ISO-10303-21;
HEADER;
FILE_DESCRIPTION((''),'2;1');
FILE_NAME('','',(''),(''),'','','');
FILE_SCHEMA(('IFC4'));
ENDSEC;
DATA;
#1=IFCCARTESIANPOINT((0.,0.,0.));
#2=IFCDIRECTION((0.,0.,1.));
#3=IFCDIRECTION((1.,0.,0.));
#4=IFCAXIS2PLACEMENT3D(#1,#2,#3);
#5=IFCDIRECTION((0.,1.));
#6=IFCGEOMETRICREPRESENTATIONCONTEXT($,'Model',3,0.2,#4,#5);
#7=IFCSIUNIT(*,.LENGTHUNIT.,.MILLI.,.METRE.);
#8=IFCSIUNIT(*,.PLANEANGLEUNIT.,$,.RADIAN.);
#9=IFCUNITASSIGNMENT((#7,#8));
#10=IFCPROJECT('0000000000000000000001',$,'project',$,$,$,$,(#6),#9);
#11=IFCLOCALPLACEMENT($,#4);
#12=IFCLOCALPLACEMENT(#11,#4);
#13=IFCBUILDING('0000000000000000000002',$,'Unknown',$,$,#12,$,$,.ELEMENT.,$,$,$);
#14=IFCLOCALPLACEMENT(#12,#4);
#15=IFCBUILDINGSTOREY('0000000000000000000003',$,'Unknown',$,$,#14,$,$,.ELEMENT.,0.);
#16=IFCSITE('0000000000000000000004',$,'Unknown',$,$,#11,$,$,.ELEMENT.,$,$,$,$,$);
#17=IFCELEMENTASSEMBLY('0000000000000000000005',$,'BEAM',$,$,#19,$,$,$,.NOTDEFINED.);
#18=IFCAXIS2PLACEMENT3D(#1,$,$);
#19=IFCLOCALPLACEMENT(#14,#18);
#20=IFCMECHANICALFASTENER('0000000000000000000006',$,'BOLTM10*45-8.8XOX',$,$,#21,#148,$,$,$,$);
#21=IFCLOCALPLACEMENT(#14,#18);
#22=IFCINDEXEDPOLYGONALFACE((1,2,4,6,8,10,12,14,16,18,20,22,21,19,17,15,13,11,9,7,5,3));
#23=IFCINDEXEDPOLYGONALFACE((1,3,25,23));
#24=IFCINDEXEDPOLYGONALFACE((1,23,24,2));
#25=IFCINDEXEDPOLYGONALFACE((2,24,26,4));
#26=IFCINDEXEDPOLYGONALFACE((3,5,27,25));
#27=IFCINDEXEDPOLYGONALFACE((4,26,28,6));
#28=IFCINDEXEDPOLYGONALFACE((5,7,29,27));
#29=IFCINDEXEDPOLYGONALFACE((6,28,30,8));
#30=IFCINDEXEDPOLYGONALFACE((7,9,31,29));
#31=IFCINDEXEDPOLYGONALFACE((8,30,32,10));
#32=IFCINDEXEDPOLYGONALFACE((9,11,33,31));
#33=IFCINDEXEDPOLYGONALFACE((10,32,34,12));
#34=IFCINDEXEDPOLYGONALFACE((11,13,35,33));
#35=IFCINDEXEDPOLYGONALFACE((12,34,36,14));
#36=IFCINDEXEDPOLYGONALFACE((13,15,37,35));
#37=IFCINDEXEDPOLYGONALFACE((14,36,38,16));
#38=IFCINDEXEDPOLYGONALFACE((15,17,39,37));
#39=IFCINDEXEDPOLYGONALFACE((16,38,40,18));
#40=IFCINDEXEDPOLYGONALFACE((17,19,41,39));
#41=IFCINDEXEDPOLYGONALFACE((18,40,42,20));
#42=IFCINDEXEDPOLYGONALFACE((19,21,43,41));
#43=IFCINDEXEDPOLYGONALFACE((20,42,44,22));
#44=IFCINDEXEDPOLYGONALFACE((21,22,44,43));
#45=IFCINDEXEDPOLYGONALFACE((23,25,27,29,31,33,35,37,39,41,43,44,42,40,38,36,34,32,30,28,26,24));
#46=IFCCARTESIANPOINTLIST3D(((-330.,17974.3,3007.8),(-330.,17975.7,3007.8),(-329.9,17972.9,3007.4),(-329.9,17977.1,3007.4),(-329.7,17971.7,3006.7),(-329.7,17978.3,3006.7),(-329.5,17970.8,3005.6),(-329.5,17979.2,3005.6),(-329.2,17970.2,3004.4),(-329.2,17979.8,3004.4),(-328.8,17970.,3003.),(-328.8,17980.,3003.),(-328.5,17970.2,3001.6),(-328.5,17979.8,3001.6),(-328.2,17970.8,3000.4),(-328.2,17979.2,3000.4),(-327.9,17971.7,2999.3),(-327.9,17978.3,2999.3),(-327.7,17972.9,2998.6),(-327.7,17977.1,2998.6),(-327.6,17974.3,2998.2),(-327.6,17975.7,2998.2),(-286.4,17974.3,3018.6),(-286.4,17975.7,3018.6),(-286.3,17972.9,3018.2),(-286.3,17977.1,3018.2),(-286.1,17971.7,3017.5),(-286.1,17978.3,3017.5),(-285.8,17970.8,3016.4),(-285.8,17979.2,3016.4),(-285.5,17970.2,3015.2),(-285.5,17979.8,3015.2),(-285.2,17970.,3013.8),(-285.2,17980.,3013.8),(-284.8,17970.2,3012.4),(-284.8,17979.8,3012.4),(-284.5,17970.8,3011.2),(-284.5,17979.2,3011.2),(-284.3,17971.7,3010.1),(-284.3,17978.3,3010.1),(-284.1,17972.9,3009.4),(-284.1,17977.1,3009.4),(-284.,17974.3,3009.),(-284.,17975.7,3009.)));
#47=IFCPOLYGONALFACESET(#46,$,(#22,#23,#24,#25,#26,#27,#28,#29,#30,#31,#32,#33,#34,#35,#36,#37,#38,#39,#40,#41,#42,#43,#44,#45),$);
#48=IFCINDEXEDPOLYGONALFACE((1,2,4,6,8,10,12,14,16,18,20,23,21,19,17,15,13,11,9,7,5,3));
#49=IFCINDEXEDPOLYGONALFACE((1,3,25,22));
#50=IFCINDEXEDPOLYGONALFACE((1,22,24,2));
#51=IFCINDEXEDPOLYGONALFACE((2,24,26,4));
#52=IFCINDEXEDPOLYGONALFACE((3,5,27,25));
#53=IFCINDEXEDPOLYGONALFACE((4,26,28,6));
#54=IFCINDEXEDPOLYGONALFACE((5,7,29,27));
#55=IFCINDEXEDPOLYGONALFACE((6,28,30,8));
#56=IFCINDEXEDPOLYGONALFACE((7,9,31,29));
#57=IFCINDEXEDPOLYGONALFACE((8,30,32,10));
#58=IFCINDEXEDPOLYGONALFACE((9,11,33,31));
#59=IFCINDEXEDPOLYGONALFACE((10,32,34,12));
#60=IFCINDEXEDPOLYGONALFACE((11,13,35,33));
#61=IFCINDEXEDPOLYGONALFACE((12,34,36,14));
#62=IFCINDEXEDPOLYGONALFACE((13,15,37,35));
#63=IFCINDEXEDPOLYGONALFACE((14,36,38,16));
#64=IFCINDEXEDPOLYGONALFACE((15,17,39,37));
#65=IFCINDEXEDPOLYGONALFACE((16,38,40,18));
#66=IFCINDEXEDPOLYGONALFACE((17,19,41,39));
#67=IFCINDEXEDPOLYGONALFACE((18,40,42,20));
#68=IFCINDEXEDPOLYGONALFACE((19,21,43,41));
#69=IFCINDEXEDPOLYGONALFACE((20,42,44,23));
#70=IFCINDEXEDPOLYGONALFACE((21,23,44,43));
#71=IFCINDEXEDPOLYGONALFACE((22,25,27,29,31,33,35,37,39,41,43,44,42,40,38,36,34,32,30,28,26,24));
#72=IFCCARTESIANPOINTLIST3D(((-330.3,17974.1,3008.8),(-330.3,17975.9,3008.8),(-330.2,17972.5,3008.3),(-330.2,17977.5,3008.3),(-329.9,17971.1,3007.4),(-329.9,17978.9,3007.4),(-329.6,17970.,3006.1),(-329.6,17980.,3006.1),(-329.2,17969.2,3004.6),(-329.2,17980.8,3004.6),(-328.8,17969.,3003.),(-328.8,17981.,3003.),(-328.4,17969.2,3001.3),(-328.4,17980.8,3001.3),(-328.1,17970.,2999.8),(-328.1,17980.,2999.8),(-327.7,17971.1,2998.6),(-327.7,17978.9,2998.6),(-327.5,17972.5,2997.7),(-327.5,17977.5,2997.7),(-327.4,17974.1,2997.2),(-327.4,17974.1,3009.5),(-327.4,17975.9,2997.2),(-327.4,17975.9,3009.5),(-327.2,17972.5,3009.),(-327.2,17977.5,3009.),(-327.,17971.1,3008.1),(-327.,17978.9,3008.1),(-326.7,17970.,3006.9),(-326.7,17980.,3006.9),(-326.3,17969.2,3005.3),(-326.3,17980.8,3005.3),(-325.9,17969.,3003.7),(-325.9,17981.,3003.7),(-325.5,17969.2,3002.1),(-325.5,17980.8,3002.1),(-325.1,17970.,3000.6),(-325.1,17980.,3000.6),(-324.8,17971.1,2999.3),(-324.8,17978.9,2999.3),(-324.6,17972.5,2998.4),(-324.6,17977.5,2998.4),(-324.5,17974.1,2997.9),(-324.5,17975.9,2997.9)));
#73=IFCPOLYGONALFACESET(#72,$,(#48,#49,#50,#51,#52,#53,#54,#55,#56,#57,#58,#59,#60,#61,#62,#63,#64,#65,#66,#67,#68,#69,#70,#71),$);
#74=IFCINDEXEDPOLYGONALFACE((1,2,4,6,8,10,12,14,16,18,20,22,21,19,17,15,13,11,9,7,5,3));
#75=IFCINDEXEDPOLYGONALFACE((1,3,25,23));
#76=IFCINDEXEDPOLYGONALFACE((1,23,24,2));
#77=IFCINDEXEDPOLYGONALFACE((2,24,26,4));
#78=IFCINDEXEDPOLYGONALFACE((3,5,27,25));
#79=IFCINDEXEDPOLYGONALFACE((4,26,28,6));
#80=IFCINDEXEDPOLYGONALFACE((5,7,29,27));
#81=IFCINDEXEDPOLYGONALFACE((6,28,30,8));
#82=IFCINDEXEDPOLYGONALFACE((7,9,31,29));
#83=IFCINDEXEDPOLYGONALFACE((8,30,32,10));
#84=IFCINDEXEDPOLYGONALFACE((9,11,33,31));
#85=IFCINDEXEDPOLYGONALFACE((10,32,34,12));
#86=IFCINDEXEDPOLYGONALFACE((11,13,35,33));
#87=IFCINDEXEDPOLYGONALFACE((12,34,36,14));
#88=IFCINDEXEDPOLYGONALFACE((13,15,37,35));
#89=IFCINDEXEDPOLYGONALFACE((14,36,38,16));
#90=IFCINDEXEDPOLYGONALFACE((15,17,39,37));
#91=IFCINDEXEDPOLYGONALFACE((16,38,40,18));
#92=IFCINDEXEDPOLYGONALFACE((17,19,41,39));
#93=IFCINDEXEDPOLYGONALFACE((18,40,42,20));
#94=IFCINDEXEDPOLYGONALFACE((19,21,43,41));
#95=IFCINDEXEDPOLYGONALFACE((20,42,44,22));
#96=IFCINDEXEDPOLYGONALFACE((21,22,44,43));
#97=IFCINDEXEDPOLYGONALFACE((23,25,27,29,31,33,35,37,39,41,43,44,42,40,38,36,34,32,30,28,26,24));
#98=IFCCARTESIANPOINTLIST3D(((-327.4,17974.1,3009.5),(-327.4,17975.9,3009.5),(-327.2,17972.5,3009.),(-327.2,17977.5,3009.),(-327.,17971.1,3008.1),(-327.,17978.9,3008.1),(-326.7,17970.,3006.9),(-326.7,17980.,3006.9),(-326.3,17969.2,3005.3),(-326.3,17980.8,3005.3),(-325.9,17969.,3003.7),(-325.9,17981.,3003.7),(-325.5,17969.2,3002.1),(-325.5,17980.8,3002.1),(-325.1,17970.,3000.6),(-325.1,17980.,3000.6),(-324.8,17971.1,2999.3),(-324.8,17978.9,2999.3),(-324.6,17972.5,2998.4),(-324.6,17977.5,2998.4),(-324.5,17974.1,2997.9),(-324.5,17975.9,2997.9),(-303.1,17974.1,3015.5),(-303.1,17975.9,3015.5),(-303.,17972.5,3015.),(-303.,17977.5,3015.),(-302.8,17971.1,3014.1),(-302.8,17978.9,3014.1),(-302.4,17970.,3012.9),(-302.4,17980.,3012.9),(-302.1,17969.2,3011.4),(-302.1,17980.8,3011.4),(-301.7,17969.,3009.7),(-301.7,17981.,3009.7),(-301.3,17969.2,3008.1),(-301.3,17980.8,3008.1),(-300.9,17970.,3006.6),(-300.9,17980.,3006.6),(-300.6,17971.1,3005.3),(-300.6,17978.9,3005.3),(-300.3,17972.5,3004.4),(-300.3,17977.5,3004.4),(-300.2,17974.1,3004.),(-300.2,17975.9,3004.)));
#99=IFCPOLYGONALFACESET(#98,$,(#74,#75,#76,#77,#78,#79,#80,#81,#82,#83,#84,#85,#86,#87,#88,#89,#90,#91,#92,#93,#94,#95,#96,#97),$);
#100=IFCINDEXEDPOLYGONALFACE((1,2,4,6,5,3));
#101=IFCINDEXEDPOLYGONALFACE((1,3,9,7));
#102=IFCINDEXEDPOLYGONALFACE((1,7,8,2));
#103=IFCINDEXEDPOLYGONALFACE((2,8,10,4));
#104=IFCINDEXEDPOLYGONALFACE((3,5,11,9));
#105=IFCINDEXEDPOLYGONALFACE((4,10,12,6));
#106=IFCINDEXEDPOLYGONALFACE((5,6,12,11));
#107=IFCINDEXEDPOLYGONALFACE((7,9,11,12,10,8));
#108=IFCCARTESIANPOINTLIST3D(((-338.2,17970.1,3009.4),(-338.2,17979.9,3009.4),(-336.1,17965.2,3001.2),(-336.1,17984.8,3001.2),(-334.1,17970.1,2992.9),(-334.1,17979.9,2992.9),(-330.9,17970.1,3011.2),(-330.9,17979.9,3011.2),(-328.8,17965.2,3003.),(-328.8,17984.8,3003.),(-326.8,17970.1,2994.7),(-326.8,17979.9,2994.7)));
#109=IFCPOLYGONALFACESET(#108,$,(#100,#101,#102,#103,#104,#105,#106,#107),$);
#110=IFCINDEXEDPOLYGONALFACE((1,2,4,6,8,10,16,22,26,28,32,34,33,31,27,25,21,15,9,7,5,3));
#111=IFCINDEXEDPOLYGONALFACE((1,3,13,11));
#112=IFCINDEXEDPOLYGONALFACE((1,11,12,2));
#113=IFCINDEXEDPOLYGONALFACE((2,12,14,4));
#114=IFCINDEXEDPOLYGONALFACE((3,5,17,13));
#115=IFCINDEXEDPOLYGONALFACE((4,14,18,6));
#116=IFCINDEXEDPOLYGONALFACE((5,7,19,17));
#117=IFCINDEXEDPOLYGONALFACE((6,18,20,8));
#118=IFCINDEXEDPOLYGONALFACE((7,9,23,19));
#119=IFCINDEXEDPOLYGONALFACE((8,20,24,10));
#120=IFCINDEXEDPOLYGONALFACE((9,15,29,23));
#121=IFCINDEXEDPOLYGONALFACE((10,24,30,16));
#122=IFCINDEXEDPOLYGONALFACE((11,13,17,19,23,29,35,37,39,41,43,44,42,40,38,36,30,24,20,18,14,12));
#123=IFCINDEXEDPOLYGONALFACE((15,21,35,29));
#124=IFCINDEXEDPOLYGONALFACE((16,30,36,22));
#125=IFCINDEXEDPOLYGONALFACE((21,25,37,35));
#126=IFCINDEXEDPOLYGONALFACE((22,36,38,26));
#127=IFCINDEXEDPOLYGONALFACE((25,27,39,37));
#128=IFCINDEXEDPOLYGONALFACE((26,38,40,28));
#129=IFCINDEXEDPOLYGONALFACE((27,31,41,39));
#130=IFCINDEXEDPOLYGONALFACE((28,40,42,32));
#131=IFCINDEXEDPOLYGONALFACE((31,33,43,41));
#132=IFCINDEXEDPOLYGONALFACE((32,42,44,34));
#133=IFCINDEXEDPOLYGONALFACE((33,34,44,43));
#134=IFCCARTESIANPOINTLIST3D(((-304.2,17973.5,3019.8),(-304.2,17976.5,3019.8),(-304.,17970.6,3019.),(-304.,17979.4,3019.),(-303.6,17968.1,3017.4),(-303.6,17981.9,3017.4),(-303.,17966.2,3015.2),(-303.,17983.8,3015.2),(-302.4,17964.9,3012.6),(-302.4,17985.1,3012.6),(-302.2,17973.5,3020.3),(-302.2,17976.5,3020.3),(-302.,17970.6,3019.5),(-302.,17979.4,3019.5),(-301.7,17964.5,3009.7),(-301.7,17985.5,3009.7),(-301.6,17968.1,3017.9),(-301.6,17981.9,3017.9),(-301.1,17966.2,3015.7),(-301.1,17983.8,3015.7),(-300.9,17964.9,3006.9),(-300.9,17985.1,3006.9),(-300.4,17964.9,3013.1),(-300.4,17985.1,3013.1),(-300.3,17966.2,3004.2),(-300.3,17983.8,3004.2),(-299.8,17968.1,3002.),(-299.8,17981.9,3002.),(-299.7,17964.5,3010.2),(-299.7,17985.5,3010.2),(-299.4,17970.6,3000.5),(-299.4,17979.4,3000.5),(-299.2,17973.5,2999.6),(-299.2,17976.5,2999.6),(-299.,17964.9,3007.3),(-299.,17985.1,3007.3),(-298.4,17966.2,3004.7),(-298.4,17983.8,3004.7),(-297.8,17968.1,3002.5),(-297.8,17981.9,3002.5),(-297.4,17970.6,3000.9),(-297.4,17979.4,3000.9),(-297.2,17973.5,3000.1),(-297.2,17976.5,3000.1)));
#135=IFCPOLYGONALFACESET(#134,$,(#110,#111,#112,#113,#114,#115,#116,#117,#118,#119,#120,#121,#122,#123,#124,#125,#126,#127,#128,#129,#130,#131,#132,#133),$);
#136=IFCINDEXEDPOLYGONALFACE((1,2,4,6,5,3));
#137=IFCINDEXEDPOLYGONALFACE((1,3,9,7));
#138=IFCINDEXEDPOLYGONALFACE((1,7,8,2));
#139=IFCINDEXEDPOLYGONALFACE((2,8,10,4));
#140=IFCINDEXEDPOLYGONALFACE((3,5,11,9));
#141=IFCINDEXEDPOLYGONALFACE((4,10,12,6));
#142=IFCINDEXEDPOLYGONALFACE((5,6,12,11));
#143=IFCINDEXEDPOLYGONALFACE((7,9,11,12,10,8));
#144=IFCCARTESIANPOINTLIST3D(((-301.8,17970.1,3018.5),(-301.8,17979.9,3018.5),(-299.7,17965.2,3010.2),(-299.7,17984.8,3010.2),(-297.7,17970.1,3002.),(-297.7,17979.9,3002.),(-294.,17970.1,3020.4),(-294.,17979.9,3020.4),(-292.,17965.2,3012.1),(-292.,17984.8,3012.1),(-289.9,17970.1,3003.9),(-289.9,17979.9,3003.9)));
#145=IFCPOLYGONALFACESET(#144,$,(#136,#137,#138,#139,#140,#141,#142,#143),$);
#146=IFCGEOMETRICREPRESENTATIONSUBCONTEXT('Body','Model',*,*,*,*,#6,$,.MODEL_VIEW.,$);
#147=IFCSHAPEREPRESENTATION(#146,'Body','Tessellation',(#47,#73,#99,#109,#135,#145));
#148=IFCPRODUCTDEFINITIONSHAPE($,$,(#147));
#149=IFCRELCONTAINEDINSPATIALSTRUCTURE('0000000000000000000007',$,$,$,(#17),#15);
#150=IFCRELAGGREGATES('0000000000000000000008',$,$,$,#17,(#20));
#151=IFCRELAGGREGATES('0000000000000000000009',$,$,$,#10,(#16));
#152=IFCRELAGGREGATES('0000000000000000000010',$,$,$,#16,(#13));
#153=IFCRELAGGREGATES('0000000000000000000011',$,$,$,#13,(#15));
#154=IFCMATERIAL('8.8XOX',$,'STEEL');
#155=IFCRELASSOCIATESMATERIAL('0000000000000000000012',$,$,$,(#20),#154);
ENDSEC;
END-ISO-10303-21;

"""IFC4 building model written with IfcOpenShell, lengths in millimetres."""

from ifc_helpers import new_model, si_unit, direction, frame, origin_with_axes, place, context, subcontext, project, spatial, line, arc, indexed_curve, outline, extrude, source, transform, mapped, material, element, aggregate, save


model = new_model("IFC4")

# Units and contexts
model_context = context("Model", 3, precision=0.2, world=origin_with_axes(), true_north=direction((0.0, 1.0)))
body_context = subcontext(model_context, "Body", "Model", "MODEL_VIEW")
ifc_project = project(units=[si_unit("LENGTHUNIT", "METRE", prefix="MILLI"), si_unit("PLANEANGLEUNIT", "RADIAN")], contexts=[model_context])

# Site, building, storey
site_placement = place(None, origin_with_axes())
site = spatial("IfcSite", under=ifc_project, at=site_placement, Name="Unknown", CompositionType="ELEMENT")
building_placement = place(site_placement, origin_with_axes())
building = spatial("IfcBuilding", under=site, at=building_placement, Name="Unknown", CompositionType="ELEMENT")
storey_placement = place(building_placement, origin_with_axes())
storey = spatial("IfcBuildingStorey", under=building, at=storey_placement, Name="Unknown", CompositionType="ELEMENT", Elevation=0.0)

# Element assembly, mechanical fastener
ifc_material_1 = material(Name="8.8XOX", Category="STEEL")
shared_shape_1 = source(origin_with_axes(), body_context, "Body", "SweptSolid", [
    extrude(outline(indexed_curve([(5.0, 0.0), (0.0, 5.0), (-5.0, 0.0), (0.0, -5.0)], segments=[arc(1, 2, 3), arc(3, 4, 1)])), frame((0.0, 0.0, 3.8), z_axis=(0.0, 0.0, -1.0), x_axis=(0.0, 1.0, 0.0)), (0.0, 0.0, 1.0), 45.0),
    extrude(outline(indexed_curve([(6.0, 0.0), (0.0, 6.0), (-6.0, 0.0), (0.0, -6.0)], segments=[arc(1, 2, 3), arc(3, 4, 1)])), frame((0.0, 0.0, 3.8), z_axis=(0.0, 0.0, -1.0), x_axis=(0.0, 1.0, 0.0)), (0.0, 0.0, 1.0), 3.0),
    extrude(outline(indexed_curve([(6.0, 0.0), (0.0, 6.0), (-6.0, 0.0), (0.0, -6.0)], segments=[arc(1, 2, 3), arc(3, 4, 1)])), frame((0.0, 0.0, 0.8), z_axis=(0.0, 0.0, -1.0), x_axis=(0.0, 1.0, 0.0)), (0.0, 0.0, 1.0), 25.0),
    extrude(outline(indexed_curve([(9.8, 0.0), (4.9, 8.5), (-4.9, 8.5), (-9.8, 0.0), (-4.9, -8.5), (4.9, -8.5)], segments=[line(1, 2, 3, 4, 5, 6, 1)])), frame((0.0, 0.0, 11.2), z_axis=(0.0, 0.0, -1.0), x_axis=(0.0, 1.0, 0.0)), (0.0, 0.0, 1.0), 7.5),
    extrude(outline(indexed_curve([(10.5, 0.0), (0.0, 10.5), (-10.5, 0.0), (0.0, -10.5)], segments=[arc(1, 2, 3), arc(3, 4, 1)])), frame((0.0, 0.0, -24.2), z_axis=(0.0, 0.0, -1.0), x_axis=(0.0, 1.0, 0.0)), (0.0, 0.0, 1.0), 2.0),
    extrude(outline(indexed_curve([(9.8, 0.0), (4.9, 8.5), (-4.9, 8.5), (-9.8, 0.0), (-4.9, -8.5), (4.9, -8.5)], segments=[line(1, 2, 3, 4, 5, 6, 1)])), frame((0.0, 0.0, -26.2), z_axis=(0.0, 0.0, -1.0), x_axis=(0.0, 1.0, 0.0)), (0.0, 0.0, 1.0), 8.0),
])
assembly_1_placement = place(storey_placement, frame((-315.0, 12000.0, 3011.6), z_axis=(0.970613, 0.0, 0.240648), x_axis=(0.0, 1.0, 0.0)))
assembly_1 = element("IfcElementAssembly", 1, at=assembly_1_placement, inside=storey, Name="BEAM", PredefinedType="NOTDEFINED")
mechanical_fastener_1_placement = place(assembly_1_placement, frame((5975.0, -5.0, -11.8), z_axis=(0.0, 0.0, -1.0), x_axis=(0.0, 1.0, 0.0)))
mechanical_fastener_1 = element("IfcMechanicalFastener", 2, at=mechanical_fastener_1_placement, material=ifc_material_1, Name="BOLTM10*45-8.8XOX", context=body_context, shape_type="MappedRepresentation", body=[
    mapped(shared_shape_1, transform((0.0, 0.0, 0.0))),
])
aggregate(assembly_1, [mechanical_fastener_1])

save(model, "model.ifc")
